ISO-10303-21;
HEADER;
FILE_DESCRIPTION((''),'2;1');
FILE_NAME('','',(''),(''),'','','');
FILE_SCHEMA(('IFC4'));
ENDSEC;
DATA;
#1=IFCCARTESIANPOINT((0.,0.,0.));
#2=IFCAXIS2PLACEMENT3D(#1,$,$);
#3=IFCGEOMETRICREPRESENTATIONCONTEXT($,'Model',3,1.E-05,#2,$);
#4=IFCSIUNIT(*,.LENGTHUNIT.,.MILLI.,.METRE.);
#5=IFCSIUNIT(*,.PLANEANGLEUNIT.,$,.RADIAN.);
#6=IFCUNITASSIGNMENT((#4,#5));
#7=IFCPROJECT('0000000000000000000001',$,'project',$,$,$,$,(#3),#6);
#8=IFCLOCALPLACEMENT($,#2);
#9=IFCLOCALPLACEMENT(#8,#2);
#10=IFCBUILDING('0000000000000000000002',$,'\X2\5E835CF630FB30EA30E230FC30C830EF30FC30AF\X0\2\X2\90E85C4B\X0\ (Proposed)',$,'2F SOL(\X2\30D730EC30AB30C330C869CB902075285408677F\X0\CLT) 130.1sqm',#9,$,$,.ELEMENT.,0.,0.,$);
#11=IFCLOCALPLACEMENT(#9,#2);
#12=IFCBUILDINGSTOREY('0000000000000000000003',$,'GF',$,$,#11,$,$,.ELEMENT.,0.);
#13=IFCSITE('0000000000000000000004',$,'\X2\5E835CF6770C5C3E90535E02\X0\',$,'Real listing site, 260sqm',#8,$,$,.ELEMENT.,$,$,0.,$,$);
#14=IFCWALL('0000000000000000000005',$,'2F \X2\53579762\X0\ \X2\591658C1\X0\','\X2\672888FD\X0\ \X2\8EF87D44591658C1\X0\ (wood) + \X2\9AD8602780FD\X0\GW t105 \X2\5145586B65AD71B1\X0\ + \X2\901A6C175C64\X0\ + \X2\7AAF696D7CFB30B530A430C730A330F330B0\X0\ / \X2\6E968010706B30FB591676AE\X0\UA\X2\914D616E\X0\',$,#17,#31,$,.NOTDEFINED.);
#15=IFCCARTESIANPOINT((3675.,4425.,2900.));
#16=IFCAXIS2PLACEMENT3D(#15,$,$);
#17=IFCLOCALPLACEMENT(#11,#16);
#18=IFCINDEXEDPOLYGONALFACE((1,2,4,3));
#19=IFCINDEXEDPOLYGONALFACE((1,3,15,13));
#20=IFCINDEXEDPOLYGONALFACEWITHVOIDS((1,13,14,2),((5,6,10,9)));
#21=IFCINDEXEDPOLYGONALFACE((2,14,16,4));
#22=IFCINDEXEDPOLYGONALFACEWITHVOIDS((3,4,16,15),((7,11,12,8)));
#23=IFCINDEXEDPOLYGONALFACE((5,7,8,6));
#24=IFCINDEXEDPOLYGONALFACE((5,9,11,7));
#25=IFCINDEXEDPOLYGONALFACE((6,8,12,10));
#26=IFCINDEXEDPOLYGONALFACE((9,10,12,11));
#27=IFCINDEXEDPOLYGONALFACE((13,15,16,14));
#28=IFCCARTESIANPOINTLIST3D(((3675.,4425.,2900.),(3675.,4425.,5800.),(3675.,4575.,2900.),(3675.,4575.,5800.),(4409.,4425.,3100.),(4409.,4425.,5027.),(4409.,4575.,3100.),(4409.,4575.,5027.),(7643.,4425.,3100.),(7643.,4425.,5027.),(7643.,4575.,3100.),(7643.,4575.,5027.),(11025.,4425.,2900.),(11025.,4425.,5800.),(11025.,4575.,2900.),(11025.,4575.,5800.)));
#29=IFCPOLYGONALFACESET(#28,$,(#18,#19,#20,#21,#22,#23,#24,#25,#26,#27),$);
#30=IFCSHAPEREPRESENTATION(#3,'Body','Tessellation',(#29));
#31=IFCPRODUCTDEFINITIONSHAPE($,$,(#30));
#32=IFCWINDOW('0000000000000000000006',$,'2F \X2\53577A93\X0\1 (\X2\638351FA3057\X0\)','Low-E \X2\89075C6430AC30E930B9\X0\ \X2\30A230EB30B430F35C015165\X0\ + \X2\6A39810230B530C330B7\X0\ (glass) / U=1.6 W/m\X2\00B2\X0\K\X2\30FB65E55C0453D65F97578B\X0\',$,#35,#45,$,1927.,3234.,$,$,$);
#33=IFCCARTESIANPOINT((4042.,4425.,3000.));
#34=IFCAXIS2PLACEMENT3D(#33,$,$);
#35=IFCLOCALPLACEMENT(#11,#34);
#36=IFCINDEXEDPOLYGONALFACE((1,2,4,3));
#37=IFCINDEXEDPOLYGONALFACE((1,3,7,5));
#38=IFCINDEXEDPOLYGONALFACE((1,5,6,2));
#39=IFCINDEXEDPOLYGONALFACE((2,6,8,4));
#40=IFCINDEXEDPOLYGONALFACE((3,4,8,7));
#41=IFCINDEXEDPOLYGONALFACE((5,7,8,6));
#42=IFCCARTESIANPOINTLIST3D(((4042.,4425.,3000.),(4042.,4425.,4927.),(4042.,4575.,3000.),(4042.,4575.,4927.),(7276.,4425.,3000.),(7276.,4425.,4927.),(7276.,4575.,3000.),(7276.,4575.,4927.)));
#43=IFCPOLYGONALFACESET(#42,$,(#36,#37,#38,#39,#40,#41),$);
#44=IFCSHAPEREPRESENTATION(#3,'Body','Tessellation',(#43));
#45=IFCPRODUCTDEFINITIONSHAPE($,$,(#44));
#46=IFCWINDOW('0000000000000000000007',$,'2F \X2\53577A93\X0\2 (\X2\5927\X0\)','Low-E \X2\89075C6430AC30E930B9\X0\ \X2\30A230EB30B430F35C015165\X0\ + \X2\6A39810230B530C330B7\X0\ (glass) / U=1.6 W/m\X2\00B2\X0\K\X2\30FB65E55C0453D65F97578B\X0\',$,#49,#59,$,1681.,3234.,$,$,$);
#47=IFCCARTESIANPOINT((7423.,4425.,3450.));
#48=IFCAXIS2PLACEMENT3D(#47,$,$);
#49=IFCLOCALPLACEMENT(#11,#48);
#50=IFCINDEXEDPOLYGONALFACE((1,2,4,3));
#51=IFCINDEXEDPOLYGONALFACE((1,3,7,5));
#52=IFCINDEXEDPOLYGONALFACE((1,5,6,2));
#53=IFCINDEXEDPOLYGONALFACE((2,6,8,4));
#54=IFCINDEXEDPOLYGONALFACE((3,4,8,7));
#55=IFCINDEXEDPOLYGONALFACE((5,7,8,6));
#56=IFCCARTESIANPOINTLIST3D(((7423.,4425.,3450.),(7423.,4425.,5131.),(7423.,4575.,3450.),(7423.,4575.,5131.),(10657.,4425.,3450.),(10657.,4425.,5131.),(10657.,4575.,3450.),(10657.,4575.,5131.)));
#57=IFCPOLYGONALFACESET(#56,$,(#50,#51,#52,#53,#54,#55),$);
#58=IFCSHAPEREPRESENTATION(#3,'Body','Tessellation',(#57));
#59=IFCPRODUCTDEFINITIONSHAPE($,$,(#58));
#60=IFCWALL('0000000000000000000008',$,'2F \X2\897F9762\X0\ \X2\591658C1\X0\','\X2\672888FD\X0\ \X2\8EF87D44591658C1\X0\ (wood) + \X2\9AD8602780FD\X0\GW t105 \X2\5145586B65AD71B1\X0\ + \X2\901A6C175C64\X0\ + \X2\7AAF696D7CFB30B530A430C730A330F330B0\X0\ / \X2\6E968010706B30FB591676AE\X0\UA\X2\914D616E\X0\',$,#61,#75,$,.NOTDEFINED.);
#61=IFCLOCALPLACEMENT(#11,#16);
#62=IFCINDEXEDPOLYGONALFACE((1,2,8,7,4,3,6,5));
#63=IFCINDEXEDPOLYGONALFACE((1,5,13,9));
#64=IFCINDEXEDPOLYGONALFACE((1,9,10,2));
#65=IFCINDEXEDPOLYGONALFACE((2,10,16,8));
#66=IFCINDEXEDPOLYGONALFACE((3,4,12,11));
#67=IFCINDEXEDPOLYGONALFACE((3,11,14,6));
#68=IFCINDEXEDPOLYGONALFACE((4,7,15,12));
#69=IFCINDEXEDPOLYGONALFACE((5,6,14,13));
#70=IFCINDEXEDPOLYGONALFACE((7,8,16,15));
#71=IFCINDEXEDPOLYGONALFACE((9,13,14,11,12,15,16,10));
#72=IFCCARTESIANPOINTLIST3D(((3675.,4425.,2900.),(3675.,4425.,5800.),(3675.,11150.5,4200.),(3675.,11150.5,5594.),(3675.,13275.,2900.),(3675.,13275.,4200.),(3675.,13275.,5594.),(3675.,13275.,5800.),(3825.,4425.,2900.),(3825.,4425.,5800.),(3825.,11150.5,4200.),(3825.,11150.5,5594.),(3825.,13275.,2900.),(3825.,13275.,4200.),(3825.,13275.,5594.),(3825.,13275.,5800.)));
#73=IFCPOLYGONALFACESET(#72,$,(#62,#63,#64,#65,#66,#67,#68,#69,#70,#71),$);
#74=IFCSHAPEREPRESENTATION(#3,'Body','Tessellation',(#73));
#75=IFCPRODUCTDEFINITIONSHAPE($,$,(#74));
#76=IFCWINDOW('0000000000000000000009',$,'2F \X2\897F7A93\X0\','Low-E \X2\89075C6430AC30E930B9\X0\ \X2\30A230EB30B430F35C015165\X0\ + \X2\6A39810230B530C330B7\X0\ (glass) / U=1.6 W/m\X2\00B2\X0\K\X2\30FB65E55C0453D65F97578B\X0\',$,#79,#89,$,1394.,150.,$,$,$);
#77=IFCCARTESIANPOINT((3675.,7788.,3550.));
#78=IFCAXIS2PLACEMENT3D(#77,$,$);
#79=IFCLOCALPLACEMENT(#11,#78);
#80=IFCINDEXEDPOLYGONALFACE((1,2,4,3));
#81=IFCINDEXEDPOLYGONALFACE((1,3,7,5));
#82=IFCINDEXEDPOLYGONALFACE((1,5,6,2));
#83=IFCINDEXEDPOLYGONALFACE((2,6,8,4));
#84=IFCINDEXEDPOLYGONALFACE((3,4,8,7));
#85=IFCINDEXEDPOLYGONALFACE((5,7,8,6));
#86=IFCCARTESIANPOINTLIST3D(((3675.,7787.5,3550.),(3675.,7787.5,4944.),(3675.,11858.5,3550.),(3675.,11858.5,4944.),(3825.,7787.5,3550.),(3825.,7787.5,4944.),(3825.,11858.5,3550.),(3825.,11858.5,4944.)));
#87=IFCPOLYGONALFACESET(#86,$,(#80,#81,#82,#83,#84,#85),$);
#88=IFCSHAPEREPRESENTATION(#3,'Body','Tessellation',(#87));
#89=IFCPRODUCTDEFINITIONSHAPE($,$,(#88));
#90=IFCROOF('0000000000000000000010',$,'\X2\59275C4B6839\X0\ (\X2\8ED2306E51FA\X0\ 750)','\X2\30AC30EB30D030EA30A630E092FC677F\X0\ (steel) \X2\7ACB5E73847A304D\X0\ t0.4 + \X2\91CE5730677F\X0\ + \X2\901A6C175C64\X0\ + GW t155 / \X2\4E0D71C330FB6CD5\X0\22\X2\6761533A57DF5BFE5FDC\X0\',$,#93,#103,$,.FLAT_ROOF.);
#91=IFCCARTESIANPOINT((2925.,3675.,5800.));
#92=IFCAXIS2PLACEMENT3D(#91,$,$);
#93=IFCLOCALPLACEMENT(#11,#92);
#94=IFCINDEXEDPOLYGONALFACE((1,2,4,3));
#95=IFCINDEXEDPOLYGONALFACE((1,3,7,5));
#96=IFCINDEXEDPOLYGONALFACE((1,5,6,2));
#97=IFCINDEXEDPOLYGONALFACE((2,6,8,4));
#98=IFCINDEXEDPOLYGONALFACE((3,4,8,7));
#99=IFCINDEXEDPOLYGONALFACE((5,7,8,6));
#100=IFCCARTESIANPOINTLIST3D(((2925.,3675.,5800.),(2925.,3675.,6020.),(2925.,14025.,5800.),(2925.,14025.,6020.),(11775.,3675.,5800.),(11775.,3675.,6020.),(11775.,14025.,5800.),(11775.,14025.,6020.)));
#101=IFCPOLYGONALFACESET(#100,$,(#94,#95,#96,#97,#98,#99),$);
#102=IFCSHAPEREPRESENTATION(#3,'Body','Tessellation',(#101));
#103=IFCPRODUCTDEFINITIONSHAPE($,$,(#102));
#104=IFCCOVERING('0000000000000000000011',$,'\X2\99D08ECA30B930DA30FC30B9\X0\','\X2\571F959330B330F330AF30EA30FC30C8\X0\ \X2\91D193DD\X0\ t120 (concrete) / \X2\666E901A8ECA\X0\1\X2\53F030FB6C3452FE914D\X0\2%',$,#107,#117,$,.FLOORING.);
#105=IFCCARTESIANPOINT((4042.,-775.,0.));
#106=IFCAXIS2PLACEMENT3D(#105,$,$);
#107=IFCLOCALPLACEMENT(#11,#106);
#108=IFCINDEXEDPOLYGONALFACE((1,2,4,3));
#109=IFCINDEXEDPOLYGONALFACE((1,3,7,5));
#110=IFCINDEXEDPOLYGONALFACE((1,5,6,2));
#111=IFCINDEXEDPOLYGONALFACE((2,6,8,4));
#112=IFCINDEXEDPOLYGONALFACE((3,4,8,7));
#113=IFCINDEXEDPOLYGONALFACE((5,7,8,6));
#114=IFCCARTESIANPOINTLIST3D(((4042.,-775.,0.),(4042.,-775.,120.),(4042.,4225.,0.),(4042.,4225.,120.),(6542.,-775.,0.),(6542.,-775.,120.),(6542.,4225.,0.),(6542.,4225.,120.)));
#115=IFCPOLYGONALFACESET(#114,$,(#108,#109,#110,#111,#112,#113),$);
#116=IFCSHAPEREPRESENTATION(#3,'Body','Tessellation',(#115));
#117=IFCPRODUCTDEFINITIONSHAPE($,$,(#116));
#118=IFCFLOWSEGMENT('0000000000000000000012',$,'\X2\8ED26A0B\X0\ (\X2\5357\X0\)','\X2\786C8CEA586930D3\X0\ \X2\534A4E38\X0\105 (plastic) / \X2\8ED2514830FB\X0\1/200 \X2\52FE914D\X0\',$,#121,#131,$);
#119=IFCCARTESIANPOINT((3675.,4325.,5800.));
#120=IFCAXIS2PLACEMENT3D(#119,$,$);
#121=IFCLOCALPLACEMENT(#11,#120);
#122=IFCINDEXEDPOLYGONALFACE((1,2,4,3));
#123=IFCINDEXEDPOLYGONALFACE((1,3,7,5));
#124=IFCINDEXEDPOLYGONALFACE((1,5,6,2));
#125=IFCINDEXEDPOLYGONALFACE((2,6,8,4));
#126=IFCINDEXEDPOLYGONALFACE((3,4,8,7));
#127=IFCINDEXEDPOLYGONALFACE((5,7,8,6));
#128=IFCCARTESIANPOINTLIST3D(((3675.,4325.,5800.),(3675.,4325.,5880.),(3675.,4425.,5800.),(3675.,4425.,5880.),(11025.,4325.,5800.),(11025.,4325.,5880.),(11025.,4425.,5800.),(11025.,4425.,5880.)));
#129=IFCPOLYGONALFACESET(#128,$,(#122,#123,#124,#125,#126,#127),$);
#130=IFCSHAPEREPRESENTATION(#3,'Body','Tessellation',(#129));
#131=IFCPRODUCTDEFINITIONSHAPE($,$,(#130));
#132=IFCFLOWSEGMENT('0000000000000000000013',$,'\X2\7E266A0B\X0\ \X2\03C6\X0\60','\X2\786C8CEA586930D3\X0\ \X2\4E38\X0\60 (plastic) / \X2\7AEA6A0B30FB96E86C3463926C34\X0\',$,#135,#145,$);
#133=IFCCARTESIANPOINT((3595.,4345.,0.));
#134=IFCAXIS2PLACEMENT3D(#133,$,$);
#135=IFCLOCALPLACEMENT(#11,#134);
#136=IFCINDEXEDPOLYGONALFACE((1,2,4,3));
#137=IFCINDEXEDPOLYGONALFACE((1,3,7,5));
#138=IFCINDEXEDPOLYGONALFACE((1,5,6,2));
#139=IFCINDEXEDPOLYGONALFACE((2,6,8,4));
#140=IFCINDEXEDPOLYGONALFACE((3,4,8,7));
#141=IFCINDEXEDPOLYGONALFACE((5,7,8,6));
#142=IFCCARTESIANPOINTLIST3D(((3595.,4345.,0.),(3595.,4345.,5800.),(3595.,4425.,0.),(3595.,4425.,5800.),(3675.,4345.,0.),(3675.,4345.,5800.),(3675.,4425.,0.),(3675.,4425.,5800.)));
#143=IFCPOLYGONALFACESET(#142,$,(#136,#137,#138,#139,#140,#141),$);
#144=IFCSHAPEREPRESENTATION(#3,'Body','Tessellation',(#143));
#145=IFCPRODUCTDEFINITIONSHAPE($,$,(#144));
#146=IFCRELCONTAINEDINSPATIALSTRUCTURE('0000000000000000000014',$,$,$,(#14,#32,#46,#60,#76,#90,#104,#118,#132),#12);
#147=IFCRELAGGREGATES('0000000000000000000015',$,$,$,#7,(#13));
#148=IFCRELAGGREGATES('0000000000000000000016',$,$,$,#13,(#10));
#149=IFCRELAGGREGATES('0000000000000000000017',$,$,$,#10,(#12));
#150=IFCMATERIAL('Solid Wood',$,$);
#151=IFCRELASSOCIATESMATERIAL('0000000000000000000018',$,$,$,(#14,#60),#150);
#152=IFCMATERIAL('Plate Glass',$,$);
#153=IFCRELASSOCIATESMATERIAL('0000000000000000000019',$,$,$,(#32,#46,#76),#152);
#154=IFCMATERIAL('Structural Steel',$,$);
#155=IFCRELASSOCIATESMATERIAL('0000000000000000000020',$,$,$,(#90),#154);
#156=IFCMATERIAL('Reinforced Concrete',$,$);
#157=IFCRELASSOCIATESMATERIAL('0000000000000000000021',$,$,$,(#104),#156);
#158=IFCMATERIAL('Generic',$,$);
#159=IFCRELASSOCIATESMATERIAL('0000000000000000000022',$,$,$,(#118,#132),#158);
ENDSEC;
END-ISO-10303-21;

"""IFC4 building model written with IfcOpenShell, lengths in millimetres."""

from ifc_helpers import new_model, si_unit, frame, frame_2d, origin, place, context, project, spatial, rectangle, extrude, material, element, fill, save


model = new_model("IFC4")

# Units and contexts
model_context = context("Model", 3, precision=1e-05, world=origin())
ifc_project = project(units=[si_unit("LENGTHUNIT", "METRE", prefix="MILLI"), si_unit("PLANEANGLEUNIT", "RADIAN")], contexts=[model_context])

# Site, building, storey
site_placement = place(None, origin())
site = spatial("IfcSite", under=ifc_project, at=site_placement, Name="広島県尾道市", ObjectType="Real listing site, 260sqm", CompositionType="ELEMENT", RefElevation=0.0)
building_placement = place(site_placement, origin())
building = spatial("IfcBuilding", under=site, at=building_placement, Name="広島・リモートワーク2部屋 (Proposed)", ObjectType="2F SOL(プレカット構造用合板CLT) 130.1sqm", CompositionType="ELEMENT", ElevationOfRefHeight=0.0, ElevationOfTerrain=0.0)
storey_placement = place(building_placement, origin())
storey = spatial("IfcBuildingStorey", under=building, at=storey_placement, Name="GF", CompositionType="ELEMENT", Elevation=0.0)

# Shared definitions
ifc_material_1 = material(Name="Solid Wood")

# Shared definitions
ifc_material_2 = material(Name="Reinforced Concrete")

# Shared definitions
ifc_material_3 = material(Name="Plate Glass")

# Wall, openings, windows
wall_1_placement = place(storey_placement, frame((3675.0, 4425.0, 2900.0)))
wall_1 = element("IfcWall", 1, at=wall_1_placement, inside=storey, material=ifc_material_1, Name="2F 南面 外壁", Description="木製 軸組外壁 (wood) + 高性能GW t105 充填断熱 + 通気層 + 窯業系サイディング / 準耐火・外皮UA配慮", PredefinedType="NOTDEFINED", context=model_context, shape_type="SweptSolid", body=[
    extrude(rectangle(XDim=7350.0, YDim=150.0, at=frame_2d((3675.0, 75.0))), frame((3675.0, 4425.0, 2900.0)), (0.0, 0.0, 1.0), 2900.0),
])
opening_1_placement = place(storey_placement, frame((4042.0, 4425.0, 3000.0)))
opening_1 = element("IfcOpeningElement", 2, at=opening_1_placement, cuts=wall_1, PredefinedType="NOTDEFINED", context=model_context, shape_type="SweptSolid", body=[
    extrude(rectangle(XDim=3234.0, YDim=150.0, at=frame_2d((1617.0, 75.0))), frame((4042.0, 4425.0, 3000.0)), (0.0, 0.0, 1.0), 1927.0),
])
opening_2_placement = place(storey_placement, frame((7423.0, 4425.0, 3450.0)))
opening_2 = element("IfcOpeningElement", 3, at=opening_2_placement, cuts=wall_1, PredefinedType="NOTDEFINED", context=model_context, shape_type="SweptSolid", body=[
    extrude(rectangle(XDim=3234.0, YDim=150.0, at=frame_2d((1617.0, 75.0))), frame((7423.0, 4425.0, 3450.0)), (0.0, 0.0, 1.0), 1681.0),
])
window_1_placement = place(storey_placement, frame((4042.0, 4425.0, 3000.0)))
window_1 = element("IfcWindow", 4, at=window_1_placement, inside=storey, material=ifc_material_3, Name="2F 南窓1 (掃出し)", Description="Low-E 複層ガラス アルゴン封入 + 樹脂サッシ (glass) / U=1.6 W/m²K・日射取得型", OverallHeight=1927.0, OverallWidth=3234.0, context=model_context, shape_type="SweptSolid", body=[
    extrude(rectangle(XDim=3234.0, YDim=150.0, at=frame_2d((1617.0, 75.0))), frame((4042.0, 4425.0, 3000.0)), (0.0, 0.0, 1.0), 1927.0),
])
fill(opening_1, window_1)
window_2_placement = place(storey_placement, frame((7423.0, 4425.0, 3450.0)))
window_2 = element("IfcWindow", 5, at=window_2_placement, inside=storey, material=ifc_material_3, Name="2F 南窓2 (大)", Description="Low-E 複層ガラス アルゴン封入 + 樹脂サッシ (glass) / U=1.6 W/m²K・日射取得型", OverallHeight=1681.0, OverallWidth=3234.0, context=model_context, shape_type="SweptSolid", body=[
    extrude(rectangle(XDim=3234.0, YDim=150.0, at=frame_2d((1617.0, 75.0))), frame((7423.0, 4425.0, 3450.0)), (0.0, 0.0, 1.0), 1681.0),
])
fill(opening_2, window_2)

# Wall, opening, window
wall_2_placement = place(storey_placement, frame((3675.0, 4425.0, 2900.0)))
wall_2 = element("IfcWall", 6, at=wall_2_placement, inside=storey, material=ifc_material_1, Name="2F 西面 外壁", Description="木製 軸組外壁 (wood) + 高性能GW t105 充填断熱 + 通気層 + 窯業系サイディング / 準耐火・外皮UA配慮", PredefinedType="NOTDEFINED", context=model_context, shape_type="SweptSolid", body=[
    extrude(rectangle(XDim=150.0, YDim=8850.0, at=frame_2d((75.0, 4425.0))), frame((3675.0, 4425.0, 2900.0)), (0.0, 0.0, 1.0), 2900.0),
])
opening_3_placement = place(storey_placement, frame((3675.0, 7788.0, 3550.0)))
opening_3 = element("IfcOpeningElement", 7, at=opening_3_placement, cuts=wall_2, PredefinedType="NOTDEFINED", context=model_context, shape_type="SweptSolid", body=[
    extrude(rectangle(XDim=150.0, YDim=4071.0, at=frame_2d((75.0, 2035.0))), frame((3675.0, 7788.0, 3550.0)), (0.0, 0.0, 1.0), 1394.0),
])
window_3_placement = place(storey_placement, frame((3675.0, 7788.0, 3550.0)))
window_3 = element("IfcWindow", 8, at=window_3_placement, inside=storey, material=ifc_material_3, Name="2F 西窓", Description="Low-E 複層ガラス アルゴン封入 + 樹脂サッシ (glass) / U=1.6 W/m²K・日射取得型", OverallHeight=1394.0, OverallWidth=150.0, context=model_context, shape_type="SweptSolid", body=[
    extrude(rectangle(XDim=150.0, YDim=4071.0, at=frame_2d((75.0, 2035.0))), frame((3675.0, 7788.0, 3550.0)), (0.0, 0.0, 1.0), 1394.0),
])
fill(opening_3, window_3)

# Roof
ifc_material_4 = material(Name="Structural Steel")
roof_placement = place(storey_placement, frame((2925.0, 3675.0, 5800.0)))
element("IfcRoof", 9, at=roof_placement, inside=storey, material=ifc_material_4, Name="大屋根 (軒の出 750)", Description="ガルバリウム鋼板 (steel) 立平葺き t0.4 + 野地板 + 通気層 + GW t155 / 不燃・法22条区域対応", PredefinedType="FLAT_ROOF", context=model_context, shape_type="SweptSolid", body=[
    extrude(rectangle(XDim=8850.0, YDim=10350.0, at=frame_2d((4425.0, 5175.0))), frame((2925.0, 3675.0, 5800.0)), (0.0, 0.0, 1.0), 220.0),
])

# Covering
covering_placement = place(storey_placement, frame((4042.0, -775.0, 0.0)))
element("IfcCovering", 10, at=covering_placement, inside=storey, material=ifc_material_2, Name="駐車スペース", Description="土間コンクリート 金鏝 t120 (concrete) / 普通車1台・水勾配2%", PredefinedType="FLOORING", context=model_context, shape_type="SweptSolid", body=[
    extrude(rectangle(XDim=2500.0, YDim=5000.0, at=frame_2d((1250.0, 2500.0))), frame((4042.0, -775.0, 0.0)), (0.0, 0.0, 1.0), 120.0),
])

# Flow segments
ifc_material_5 = material(Name="Generic")
flow_segment_1_placement = place(storey_placement, frame((3675.0, 4325.0, 5800.0)))
element("IfcFlowSegment", 11, at=flow_segment_1_placement, inside=storey, material=ifc_material_5, Name="軒樋 (南)", Description="硬質塩ビ 半丸105 (plastic) / 軒先・1/200 勾配", context=model_context, shape_type="SweptSolid", body=[
    extrude(rectangle(XDim=7350.0, YDim=100.0, at=frame_2d((3675.0, 50.0))), frame((3675.0, 4325.0, 5800.0)), (0.0, 0.0, 1.0), 80.0),
])
flow_segment_2_placement = place(storey_placement, frame((3595.0, 4345.0, 0.0)))
element("IfcFlowSegment", 12, at=flow_segment_2_placement, inside=storey, material=ifc_material_5, Name="縦樋 φ60", Description="硬質塩ビ 丸60 (plastic) / 竪樋・雨水排水", context=model_context, shape_type="SweptSolid", body=[
    extrude(rectangle(XDim=80.0, YDim=80.0, at=frame_2d((40.0, 40.0))), frame((3595.0, 4345.0, 0.0)), (0.0, 0.0, 1.0), 5800.0),
])

save(model, "model.ifc")
